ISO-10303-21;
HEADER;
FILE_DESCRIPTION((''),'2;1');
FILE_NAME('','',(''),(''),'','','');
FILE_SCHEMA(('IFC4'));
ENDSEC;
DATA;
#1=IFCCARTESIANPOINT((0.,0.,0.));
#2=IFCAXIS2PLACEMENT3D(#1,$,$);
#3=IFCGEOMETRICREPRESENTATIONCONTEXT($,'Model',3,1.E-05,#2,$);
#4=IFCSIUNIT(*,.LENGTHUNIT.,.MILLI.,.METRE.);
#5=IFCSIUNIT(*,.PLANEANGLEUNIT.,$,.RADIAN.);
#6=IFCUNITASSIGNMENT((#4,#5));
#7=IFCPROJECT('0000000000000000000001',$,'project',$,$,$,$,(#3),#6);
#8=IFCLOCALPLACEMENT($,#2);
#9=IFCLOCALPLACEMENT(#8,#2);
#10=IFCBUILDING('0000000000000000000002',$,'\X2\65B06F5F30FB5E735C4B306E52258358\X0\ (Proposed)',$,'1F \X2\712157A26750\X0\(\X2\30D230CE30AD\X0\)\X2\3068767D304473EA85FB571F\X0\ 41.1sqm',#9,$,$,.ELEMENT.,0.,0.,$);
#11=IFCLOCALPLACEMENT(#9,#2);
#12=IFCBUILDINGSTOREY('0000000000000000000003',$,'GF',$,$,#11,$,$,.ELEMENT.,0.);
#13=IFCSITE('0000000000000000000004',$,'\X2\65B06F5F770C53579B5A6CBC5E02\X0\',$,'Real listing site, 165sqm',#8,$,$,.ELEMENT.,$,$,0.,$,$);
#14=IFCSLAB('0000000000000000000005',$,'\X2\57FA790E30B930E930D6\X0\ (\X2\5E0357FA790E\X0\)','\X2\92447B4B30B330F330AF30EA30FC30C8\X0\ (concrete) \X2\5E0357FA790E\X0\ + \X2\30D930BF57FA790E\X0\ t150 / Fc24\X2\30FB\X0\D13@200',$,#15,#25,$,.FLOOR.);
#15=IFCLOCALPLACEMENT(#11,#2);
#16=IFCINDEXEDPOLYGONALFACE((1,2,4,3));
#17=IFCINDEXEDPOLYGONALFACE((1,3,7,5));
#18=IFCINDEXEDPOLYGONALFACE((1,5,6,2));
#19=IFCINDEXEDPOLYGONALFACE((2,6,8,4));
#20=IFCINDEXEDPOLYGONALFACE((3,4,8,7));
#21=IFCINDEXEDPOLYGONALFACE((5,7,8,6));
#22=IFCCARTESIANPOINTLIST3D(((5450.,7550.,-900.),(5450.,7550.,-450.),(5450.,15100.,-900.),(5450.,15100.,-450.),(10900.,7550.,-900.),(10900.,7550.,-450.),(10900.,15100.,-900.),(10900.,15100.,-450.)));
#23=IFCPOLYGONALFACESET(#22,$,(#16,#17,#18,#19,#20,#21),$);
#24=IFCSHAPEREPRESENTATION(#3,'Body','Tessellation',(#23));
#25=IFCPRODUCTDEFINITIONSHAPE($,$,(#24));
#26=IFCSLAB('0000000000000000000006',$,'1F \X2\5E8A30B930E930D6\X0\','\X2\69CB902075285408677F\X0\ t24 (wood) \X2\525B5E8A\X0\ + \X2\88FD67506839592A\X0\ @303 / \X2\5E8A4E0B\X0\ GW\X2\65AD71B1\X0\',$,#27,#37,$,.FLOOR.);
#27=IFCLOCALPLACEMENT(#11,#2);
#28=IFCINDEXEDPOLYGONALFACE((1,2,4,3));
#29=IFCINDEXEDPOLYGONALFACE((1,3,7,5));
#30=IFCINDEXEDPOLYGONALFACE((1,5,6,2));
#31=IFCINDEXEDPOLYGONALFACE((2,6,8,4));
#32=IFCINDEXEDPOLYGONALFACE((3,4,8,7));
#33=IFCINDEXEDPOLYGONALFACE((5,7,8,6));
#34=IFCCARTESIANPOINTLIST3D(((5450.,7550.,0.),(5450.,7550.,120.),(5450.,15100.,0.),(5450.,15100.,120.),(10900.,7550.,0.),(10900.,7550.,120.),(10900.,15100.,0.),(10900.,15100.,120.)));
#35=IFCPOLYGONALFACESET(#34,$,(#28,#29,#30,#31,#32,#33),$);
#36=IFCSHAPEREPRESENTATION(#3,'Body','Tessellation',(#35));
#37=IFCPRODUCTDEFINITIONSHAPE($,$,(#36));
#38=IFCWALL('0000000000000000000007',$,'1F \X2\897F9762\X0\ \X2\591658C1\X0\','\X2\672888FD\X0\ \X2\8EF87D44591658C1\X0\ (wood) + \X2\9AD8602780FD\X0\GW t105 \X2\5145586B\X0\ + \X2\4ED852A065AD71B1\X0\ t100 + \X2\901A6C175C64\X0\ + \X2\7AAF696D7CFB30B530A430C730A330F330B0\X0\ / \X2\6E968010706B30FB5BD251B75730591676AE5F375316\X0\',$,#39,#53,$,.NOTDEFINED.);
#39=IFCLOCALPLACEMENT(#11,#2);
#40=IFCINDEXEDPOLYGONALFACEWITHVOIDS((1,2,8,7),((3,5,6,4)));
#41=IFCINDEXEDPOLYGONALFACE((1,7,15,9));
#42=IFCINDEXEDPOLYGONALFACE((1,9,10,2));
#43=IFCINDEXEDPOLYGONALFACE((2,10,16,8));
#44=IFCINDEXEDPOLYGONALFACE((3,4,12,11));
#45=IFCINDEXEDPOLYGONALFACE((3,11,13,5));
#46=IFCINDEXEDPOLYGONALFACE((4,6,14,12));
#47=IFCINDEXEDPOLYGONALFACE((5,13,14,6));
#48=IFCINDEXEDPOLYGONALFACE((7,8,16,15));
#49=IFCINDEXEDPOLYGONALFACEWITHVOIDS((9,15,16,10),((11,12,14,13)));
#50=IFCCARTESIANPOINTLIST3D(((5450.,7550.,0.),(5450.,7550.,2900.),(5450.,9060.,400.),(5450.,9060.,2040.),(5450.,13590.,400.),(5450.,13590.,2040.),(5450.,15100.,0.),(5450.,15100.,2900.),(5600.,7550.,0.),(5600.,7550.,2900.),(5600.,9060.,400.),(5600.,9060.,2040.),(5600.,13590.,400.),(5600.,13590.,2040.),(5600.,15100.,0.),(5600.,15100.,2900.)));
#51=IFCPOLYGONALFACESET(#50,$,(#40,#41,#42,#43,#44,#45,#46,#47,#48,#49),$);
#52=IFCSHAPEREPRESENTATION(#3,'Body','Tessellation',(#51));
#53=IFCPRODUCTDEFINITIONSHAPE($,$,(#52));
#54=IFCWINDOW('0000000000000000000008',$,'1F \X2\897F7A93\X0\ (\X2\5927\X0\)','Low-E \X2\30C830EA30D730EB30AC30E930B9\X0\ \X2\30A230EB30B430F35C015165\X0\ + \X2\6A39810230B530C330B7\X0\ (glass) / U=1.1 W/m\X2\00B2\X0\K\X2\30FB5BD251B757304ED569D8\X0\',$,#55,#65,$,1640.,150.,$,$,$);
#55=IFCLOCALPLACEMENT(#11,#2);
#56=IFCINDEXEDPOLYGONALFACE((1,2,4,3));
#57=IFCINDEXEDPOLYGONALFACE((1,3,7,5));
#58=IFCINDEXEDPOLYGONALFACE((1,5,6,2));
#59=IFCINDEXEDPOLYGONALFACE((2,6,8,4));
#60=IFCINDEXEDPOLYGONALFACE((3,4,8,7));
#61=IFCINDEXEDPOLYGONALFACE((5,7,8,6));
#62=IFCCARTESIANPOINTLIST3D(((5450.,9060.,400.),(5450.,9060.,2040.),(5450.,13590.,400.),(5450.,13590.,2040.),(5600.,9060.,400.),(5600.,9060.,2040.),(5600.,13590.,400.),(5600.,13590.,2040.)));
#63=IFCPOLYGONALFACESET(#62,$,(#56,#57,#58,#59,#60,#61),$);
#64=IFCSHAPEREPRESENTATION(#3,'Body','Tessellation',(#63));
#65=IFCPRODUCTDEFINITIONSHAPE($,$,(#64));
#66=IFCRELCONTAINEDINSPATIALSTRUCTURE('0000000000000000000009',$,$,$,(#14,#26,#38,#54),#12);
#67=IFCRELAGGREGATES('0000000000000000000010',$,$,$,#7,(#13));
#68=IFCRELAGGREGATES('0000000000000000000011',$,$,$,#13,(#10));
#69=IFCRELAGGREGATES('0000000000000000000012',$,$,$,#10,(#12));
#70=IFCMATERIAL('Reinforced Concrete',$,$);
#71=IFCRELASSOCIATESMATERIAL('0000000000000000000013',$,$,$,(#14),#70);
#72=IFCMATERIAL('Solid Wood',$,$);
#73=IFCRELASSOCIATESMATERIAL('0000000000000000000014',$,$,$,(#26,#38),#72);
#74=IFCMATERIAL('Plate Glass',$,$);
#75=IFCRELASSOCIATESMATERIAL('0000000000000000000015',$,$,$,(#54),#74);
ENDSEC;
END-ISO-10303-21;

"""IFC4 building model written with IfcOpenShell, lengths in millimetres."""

from ifc_helpers import new_model, si_unit, frame, frame_2d, origin, place, context, project, spatial, rectangle, extrude, material, element, fill, save


model = new_model("IFC4")

# Units and contexts
model_context = context("Model", 3, precision=1e-05, world=origin())
ifc_project = project(units=[si_unit("LENGTHUNIT", "METRE", prefix="MILLI"), si_unit("PLANEANGLEUNIT", "RADIAN")], contexts=[model_context])

# Site, building, storey
site_placement = place(None, origin())
site = spatial("IfcSite", under=ifc_project, at=site_placement, Name="新潟県南魚沼市", ObjectType="Real listing site, 165sqm", CompositionType="ELEMENT", RefElevation=0.0)
building_placement = place(site_placement, origin())
building = spatial("IfcBuilding", under=site, at=building_placement, Name="新潟・平屋の別荘 (Proposed)", ObjectType="1F 無垢材(ヒノキ)と白い珪藻土 41.1sqm", CompositionType="ELEMENT", ElevationOfRefHeight=0.0, ElevationOfTerrain=0.0)
storey_placement = place(building_placement, origin())
storey = spatial("IfcBuildingStorey", under=building, at=storey_placement, Name="GF", CompositionType="ELEMENT", Elevation=0.0)

# Shared definitions
ifc_material_1 = material(Name="Solid Wood")

# Slabs
ifc_material_2 = material(Name="Reinforced Concrete")
slab_1_placement = place(storey_placement, frame((2725.0, 3775.0, -450.0)))
element("IfcSlab", 1, at=slab_1_placement, inside=storey, material=ifc_material_2, Name="基礎スラブ (布基礎)", Description="鉄筋コンクリート (concrete) 布基礎 + ベタ基礎 t150 / Fc24・D13@200", PredefinedType="FLOOR", context=model_context, shape_type="SweptSolid", body=[
    extrude(rectangle(XDim=5450.0, YDim=7550.0, at=frame_2d((2725.0, 3775.0))), frame((2725.0, 3775.0, -450.0)), (0.0, 0.0, 1.0), 450.0),
])
slab_2_placement = place(storey_placement, frame((2725.0, 3775.0, 0.0)))
element("IfcSlab", 2, at=slab_2_placement, inside=storey, material=ifc_material_1, Name="1F 床スラブ", Description="構造用合板 t24 (wood) 剛床 + 製材根太 @303 / 床下 GW断熱", PredefinedType="FLOOR", context=model_context, shape_type="SweptSolid", body=[
    extrude(rectangle(XDim=5450.0, YDim=7550.0, at=frame_2d((2725.0, 3775.0))), frame((2725.0, 3775.0, 0.0)), (0.0, 0.0, 1.0), 120.0),
])

# Shared definitions
ifc_material_3 = material(Name="Plate Glass")

# Wall, opening, window
wall_1_placement = place(storey_placement, frame((2725.0, 3775.0, 0.0)))
wall_1 = element("IfcWall", 3, at=wall_1_placement, inside=storey, material=ifc_material_1, Name="1F 西面 外壁", Description="木製 軸組外壁 (wood) + 高性能GW t105 充填 + 付加断熱 t100 + 通気層 + 窯業系サイディング / 準耐火・寒冷地外皮強化", PredefinedType="NOTDEFINED", context=model_context, shape_type="SweptSolid", body=[
    extrude(rectangle(XDim=150.0, YDim=7550.0, at=frame_2d((75.0, 3775.0))), frame((2725.0, 3775.0, 0.0)), (0.0, 0.0, 1.0), 2900.0),
])
opening_1_placement = place(storey_placement, frame((2725.0, 4530.0, 200.0)))
opening_1 = element("IfcOpeningElement", 4, at=opening_1_placement, cuts=wall_1, PredefinedType="NOTDEFINED", context=model_context, shape_type="SweptSolid", body=[
    extrude(rectangle(XDim=150.0, YDim=4530.0, at=frame_2d((75.0, 2265.0))), frame((2725.0, 4530.0, 200.0)), (0.0, 0.0, 1.0), 1640.0),
])
window_1_placement = place(storey_placement, frame((2725.0, 4530.0, 200.0)))
window_1 = element("IfcWindow", 5, at=window_1_placement, inside=storey, material=ifc_material_3, Name="1F 西窓 (大)", Description="Low-E トリプルガラス アルゴン封入 + 樹脂サッシ (glass) / U=1.1 W/m²K・寒冷地仕様", OverallHeight=1640.0, OverallWidth=150.0, context=model_context, shape_type="SweptSolid", body=[
    extrude(rectangle(XDim=150.0, YDim=4530.0, at=frame_2d((75.0, 2265.0))), frame((2725.0, 4530.0, 200.0)), (0.0, 0.0, 1.0), 1640.0),
])
fill(opening_1, window_1)

save(model, "model.ifc")
